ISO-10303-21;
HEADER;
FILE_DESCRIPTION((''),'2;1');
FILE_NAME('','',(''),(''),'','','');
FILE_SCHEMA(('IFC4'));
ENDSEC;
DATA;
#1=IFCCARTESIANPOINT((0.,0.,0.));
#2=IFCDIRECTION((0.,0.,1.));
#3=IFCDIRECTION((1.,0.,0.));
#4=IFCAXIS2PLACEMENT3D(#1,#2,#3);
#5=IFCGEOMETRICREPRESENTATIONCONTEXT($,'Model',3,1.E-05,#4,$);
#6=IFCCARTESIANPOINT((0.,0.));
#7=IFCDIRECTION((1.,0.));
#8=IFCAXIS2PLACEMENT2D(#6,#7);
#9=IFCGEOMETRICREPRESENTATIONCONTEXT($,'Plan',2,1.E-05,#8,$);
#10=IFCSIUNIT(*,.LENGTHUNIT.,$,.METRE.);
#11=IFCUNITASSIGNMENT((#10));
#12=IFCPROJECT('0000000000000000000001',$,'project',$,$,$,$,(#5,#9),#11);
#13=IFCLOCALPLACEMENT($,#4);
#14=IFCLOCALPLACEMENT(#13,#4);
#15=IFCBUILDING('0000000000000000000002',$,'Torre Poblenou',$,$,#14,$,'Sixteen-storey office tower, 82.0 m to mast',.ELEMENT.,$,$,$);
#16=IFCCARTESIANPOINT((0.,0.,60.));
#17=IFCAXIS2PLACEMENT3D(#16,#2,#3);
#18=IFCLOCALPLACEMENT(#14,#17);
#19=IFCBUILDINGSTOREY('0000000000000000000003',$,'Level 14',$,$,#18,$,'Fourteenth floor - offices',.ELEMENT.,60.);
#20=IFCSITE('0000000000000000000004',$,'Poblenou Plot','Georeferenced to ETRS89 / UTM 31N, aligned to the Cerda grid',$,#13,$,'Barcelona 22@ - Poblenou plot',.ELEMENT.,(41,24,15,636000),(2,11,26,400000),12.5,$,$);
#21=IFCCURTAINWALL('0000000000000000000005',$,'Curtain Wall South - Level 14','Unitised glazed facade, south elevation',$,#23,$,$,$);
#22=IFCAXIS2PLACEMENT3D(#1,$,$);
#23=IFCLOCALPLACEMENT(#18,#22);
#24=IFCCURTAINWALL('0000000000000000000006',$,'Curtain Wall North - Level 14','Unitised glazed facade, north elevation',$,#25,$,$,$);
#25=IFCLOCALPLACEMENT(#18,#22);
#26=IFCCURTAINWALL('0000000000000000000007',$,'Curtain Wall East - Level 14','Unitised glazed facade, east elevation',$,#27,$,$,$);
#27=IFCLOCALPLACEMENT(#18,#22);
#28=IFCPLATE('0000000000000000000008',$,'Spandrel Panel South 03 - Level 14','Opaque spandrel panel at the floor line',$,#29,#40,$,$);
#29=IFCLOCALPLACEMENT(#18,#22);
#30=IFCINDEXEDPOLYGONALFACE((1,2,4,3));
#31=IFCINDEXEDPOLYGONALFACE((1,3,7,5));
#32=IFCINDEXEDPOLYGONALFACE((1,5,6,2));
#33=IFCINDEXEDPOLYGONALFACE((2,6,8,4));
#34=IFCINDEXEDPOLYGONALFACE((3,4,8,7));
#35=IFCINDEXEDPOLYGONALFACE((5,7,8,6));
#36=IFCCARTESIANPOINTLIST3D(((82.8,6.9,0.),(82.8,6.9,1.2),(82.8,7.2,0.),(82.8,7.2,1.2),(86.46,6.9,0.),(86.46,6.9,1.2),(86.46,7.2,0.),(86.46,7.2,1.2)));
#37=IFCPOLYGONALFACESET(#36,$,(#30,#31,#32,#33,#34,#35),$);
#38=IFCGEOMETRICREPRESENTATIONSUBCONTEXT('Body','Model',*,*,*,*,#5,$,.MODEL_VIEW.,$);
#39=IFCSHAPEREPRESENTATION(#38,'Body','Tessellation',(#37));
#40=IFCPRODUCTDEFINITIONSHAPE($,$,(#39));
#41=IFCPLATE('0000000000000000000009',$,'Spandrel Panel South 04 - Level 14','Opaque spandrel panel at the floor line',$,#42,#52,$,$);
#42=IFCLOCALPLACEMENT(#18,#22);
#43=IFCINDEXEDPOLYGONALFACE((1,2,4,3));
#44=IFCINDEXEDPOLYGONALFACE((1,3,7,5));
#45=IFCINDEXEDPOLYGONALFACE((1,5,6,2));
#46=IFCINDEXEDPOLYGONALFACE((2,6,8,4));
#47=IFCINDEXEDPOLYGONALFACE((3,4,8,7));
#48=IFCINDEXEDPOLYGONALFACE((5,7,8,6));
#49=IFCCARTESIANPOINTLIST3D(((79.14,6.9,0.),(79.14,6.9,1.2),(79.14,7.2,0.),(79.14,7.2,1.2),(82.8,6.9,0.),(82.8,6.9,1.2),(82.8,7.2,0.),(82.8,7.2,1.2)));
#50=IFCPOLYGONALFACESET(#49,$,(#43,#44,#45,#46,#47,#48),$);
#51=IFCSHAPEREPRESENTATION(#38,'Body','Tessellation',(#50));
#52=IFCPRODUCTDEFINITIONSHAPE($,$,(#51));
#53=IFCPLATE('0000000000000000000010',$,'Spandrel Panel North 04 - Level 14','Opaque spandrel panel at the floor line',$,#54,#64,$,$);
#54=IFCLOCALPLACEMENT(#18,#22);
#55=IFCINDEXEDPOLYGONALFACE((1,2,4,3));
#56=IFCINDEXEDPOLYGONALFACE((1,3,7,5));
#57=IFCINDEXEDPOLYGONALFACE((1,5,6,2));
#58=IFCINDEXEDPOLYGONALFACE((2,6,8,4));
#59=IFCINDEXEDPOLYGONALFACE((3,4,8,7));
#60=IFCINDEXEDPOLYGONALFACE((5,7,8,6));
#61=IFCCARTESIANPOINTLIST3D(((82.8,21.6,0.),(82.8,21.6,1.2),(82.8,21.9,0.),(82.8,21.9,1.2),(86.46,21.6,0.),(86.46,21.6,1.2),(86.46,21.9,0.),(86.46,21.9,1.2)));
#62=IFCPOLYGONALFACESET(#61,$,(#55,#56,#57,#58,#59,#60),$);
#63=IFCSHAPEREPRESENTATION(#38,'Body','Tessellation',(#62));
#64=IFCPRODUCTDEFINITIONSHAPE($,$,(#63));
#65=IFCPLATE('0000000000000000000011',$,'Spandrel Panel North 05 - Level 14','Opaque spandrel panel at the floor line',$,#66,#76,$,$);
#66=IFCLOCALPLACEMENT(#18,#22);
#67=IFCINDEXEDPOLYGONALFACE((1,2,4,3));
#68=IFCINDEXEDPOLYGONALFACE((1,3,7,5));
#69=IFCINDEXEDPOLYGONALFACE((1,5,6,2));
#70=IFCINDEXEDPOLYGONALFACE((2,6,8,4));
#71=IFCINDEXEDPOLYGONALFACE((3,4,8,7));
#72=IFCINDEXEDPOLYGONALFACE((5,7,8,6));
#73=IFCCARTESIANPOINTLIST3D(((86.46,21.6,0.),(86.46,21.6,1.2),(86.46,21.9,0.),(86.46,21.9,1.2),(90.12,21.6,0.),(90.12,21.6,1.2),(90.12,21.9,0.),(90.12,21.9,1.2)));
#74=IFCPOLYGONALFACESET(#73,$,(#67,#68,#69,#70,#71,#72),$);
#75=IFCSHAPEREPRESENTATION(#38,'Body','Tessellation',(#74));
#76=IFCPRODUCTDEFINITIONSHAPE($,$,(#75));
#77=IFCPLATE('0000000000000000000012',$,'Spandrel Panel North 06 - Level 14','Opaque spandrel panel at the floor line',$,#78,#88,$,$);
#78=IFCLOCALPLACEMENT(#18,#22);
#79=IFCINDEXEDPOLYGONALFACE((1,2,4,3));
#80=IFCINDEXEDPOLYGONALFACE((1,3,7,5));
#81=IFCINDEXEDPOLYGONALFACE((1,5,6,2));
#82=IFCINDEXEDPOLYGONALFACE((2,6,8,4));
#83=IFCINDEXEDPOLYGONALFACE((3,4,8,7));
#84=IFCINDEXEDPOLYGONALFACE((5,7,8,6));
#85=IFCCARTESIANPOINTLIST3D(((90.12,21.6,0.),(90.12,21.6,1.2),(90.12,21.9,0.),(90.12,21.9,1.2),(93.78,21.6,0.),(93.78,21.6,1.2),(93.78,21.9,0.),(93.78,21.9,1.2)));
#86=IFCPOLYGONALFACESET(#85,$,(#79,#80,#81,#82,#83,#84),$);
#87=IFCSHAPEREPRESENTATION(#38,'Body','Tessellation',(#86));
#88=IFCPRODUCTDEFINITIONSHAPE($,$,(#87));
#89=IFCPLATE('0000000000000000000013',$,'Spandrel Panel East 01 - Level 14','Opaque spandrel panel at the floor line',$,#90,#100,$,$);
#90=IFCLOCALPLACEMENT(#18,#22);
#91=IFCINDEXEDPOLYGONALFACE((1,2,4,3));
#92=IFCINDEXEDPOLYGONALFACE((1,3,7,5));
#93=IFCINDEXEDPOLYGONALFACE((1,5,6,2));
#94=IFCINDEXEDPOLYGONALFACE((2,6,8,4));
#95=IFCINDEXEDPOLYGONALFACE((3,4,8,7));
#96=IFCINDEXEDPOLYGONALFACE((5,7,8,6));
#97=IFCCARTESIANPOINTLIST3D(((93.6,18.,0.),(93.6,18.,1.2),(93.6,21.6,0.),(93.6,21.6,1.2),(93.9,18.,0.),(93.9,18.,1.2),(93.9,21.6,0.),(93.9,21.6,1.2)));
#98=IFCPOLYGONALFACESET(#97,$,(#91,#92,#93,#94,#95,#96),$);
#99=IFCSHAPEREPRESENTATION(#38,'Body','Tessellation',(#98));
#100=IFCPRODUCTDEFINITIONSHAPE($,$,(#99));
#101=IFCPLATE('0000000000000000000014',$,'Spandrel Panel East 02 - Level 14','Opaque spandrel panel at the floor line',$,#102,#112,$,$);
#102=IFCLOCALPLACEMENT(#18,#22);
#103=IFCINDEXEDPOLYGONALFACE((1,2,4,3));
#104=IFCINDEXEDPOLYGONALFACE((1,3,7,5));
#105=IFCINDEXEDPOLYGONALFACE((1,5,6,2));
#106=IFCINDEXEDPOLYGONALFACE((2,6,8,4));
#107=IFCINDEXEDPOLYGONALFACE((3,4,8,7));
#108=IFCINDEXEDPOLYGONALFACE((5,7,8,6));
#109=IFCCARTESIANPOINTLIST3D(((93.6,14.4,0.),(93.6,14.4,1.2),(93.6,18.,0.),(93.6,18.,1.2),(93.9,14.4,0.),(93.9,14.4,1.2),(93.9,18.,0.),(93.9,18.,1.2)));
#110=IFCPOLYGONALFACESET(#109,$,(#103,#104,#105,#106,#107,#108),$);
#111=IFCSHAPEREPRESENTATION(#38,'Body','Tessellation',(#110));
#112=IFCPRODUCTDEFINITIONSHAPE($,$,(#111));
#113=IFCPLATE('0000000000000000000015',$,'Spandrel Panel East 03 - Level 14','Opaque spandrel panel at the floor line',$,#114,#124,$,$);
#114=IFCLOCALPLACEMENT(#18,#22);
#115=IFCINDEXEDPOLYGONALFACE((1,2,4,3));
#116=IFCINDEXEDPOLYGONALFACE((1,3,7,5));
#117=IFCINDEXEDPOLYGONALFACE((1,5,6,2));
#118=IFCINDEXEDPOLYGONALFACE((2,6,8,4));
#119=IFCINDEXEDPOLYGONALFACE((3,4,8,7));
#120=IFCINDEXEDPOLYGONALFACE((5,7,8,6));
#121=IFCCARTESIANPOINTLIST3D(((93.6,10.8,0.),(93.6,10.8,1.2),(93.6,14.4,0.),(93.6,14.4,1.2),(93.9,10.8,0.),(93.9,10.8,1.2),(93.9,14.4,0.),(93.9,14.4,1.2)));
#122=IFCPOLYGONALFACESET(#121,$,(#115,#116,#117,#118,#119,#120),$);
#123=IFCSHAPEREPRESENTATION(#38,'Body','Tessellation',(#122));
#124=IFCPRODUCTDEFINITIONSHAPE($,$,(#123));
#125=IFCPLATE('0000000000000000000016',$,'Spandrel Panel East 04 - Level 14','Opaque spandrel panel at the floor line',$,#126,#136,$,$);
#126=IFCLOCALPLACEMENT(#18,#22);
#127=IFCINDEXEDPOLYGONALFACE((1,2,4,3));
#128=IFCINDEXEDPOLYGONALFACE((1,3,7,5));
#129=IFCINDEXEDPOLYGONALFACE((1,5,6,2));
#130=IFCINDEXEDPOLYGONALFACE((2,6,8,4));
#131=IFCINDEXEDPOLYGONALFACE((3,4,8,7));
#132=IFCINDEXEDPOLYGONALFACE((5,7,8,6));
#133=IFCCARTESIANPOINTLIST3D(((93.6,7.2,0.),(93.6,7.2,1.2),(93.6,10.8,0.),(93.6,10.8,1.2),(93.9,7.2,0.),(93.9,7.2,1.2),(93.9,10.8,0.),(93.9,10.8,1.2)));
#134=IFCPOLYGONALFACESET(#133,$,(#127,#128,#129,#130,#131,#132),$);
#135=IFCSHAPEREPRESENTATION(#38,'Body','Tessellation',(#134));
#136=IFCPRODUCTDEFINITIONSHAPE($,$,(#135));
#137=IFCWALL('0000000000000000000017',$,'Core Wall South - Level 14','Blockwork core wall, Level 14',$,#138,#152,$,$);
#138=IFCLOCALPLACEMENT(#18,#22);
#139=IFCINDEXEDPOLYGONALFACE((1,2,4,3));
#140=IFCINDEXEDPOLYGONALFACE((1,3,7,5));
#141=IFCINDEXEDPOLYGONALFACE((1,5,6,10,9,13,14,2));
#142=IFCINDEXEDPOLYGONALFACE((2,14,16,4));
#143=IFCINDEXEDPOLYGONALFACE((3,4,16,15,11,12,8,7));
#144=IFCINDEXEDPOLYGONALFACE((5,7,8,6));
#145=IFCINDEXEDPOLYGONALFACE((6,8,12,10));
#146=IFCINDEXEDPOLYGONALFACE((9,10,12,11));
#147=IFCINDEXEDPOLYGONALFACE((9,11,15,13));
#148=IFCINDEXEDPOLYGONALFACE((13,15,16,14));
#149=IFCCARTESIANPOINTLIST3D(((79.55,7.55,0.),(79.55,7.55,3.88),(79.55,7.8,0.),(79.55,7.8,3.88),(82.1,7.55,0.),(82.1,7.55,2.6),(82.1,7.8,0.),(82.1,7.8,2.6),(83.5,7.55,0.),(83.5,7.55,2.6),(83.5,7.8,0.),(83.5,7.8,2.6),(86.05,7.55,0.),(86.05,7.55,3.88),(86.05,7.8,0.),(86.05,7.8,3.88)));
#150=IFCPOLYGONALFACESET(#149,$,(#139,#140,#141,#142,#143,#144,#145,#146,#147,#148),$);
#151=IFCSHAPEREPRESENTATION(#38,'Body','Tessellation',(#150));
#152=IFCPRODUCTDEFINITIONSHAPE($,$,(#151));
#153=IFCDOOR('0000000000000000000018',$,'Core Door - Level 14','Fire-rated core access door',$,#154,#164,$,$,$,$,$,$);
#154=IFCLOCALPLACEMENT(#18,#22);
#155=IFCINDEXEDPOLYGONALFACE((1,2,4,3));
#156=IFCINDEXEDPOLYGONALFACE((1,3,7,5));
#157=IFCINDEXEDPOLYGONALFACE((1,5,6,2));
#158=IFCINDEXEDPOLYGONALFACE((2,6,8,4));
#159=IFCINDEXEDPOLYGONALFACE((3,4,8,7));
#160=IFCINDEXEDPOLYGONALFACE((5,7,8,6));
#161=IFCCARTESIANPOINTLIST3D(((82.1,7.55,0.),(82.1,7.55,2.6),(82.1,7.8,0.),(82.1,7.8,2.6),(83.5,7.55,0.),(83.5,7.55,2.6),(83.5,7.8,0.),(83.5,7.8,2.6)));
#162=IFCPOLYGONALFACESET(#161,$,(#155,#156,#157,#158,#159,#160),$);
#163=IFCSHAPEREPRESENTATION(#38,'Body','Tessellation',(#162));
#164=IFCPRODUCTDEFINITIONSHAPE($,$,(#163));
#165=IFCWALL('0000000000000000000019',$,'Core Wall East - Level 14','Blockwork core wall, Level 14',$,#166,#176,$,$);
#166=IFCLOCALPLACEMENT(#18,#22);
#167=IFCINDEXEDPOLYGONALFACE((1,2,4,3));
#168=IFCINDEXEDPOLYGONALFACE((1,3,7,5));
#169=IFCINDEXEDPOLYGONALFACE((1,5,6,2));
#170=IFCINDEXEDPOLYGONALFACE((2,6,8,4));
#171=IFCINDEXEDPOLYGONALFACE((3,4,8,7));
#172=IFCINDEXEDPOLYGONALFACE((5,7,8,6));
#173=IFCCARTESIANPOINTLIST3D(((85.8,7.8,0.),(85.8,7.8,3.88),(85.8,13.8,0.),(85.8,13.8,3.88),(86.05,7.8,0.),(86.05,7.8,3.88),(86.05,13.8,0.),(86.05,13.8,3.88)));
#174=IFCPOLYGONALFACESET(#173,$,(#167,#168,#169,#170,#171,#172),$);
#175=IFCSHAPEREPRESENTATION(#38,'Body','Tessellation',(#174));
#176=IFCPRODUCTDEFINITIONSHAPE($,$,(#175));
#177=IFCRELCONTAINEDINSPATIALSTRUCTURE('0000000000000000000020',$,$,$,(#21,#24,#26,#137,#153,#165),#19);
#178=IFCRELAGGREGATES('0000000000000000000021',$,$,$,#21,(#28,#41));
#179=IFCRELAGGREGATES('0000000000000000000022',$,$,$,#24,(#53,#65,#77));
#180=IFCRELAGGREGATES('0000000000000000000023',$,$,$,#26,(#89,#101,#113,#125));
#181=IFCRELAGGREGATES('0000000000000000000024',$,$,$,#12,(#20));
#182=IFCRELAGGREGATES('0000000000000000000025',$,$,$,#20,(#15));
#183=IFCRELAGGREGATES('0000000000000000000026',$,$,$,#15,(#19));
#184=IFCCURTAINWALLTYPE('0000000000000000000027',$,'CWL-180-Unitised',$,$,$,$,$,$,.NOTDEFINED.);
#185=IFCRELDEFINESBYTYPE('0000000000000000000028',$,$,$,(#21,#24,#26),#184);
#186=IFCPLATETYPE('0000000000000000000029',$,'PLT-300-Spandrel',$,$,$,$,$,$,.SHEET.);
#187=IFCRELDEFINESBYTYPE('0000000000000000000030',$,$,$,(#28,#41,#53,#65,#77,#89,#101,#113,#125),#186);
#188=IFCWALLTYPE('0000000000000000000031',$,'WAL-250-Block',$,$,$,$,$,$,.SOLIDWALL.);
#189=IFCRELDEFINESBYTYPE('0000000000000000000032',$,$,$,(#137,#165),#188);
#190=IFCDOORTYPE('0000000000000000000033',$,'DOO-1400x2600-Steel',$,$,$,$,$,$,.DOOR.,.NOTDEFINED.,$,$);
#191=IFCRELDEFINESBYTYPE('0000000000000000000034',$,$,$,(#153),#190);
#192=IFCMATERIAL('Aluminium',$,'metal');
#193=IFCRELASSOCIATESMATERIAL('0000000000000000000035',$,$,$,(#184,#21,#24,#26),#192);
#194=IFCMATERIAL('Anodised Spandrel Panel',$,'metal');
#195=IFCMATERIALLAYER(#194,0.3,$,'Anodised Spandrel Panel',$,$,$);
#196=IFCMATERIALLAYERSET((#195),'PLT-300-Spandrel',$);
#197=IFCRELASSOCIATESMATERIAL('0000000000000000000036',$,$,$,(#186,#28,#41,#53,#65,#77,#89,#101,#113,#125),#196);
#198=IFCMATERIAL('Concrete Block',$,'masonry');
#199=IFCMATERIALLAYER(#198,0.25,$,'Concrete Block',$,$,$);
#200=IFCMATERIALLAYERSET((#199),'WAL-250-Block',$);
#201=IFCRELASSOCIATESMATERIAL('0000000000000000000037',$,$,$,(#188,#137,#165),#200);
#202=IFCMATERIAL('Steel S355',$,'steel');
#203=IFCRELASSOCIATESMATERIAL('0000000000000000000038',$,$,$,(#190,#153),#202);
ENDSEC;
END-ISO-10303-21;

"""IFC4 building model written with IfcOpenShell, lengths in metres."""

from ifc_helpers import new_model, si_unit, frame, origin_with_axes, origin_2d_with_axis, place, context, subcontext, project, spatial, line, indexed_curve, outline, extrude, material, layer, layer_set, layer_usage, type_object, element, fill, aggregate, save


model = new_model("IFC4")

# Units and contexts
model_context = context("Model", 3, precision=1e-05, world=origin_with_axes())
plan_context = context("Plan", 2, precision=1e-05, world=origin_2d_with_axis())
body_context = subcontext(model_context, "Body", "Model", "MODEL_VIEW")
ifc_project = project(units=[si_unit("LENGTHUNIT", "METRE")], contexts=[model_context, plan_context])

# Site, building, storey
site_placement = place(None, origin_with_axes())
site = spatial("IfcSite", under=ifc_project, at=site_placement, Name="Poblenou Plot", Description="Georeferenced to ETRS89 / UTM 31N, aligned to the Cerda grid", LongName="Barcelona 22@ - Poblenou plot", CompositionType="ELEMENT", RefLatitude=(41, 24, 15, 636000), RefLongitude=(2, 11, 26, 400000), RefElevation=12.5)
building_placement = place(site_placement, origin_with_axes())
building = spatial("IfcBuilding", under=site, at=building_placement, Name="Torre Poblenou", LongName="Sixteen-storey office tower, 82.0 m to mast", CompositionType="ELEMENT")
storey_placement = place(building_placement, frame((0.0, 0.0, 60.0), z_axis=(0.0, 0.0, 1.0), x_axis=(1.0, 0.0, 0.0)))
storey = spatial("IfcBuildingStorey", under=building, at=storey_placement, Name="Level 14", LongName="Fourteenth floor - offices", CompositionType="ELEMENT", Elevation=60.0)

# Curtain walls
ifc_material_1 = material(Name="Aluminium", Category="metal")
curtain_wall_type = type_object("IfcCurtainWallType", Name="CWL-180-Unitised", PredefinedType="NOTDEFINED", material=ifc_material_1)
curtain_wall_1_placement = place(storey_placement, frame((93.78, 7.2, 0.0), z_axis=(0.0, 0.0, 1.0), x_axis=(-1.0, 0.0, 0.0)))
curtain_wall_1 = element("IfcCurtainWall", 1, at=curtain_wall_1_placement, inside=storey, type_object=curtain_wall_type, material=ifc_material_1, Name="Curtain Wall South - Level 14", Description="Unitised glazed facade, south elevation")
curtain_wall_2_placement = place(storey_placement, frame((71.82, 21.6, 0.0), z_axis=(0.0, 0.0, 1.0), x_axis=(1.0, 0.0, 0.0)))
curtain_wall_2 = element("IfcCurtainWall", 2, at=curtain_wall_2_placement, inside=storey, type_object=curtain_wall_type, material=ifc_material_1, Name="Curtain Wall North - Level 14", Description="Unitised glazed facade, north elevation")
curtain_wall_3_placement = place(storey_placement, frame((93.6, 21.6, 0.0), z_axis=(0.0, 0.0, 1.0), x_axis=(0.0, -1.0, 0.0)))
curtain_wall_3 = element("IfcCurtainWall", 3, at=curtain_wall_3_placement, inside=storey, type_object=curtain_wall_type, material=ifc_material_1, Name="Curtain Wall East - Level 14", Description="Unitised glazed facade, east elevation")

# Plates
ifc_material_2 = material(Name="Anodised Spandrel Panel", Category="metal")
ifc_layer_1 = layer(ifc_material_2, 0.3, Name="Anodised Spandrel Panel")
ifc_layer_set_1 = layer_set([ifc_layer_1], Name="PLT-300-Spandrel")
plate_type_1 = type_object("IfcPlateType", Name="PLT-300-Spandrel", PredefinedType="SHEET", material=ifc_layer_set_1)
ifc_layer_usage_1 = layer_usage(ifc_layer_set_1, "AXIS2", "POSITIVE", 0.0)
plate_1_placement = place(curtain_wall_1_placement, frame((7.32, 0.0, 0.0), z_axis=(0.0, 0.0, 1.0), x_axis=(1.0, 0.0, 0.0)))
plate_1 = element("IfcPlate", 4, at=plate_1_placement, type_object=plate_type_1, material=ifc_layer_usage_1, Name="Spandrel Panel South 03 - Level 14", Description="Opaque spandrel panel at the floor line", context=body_context, shape_type="SweptSolid", body=[
    extrude(outline(indexed_curve([(0.0, 0.0), (3.66, 0.0), (3.66, 0.3), (0.0, 0.3)], segments=[line(1, 2, 3, 4, 1)])), origin_with_axes(), (0.0, 0.0, 1.0), 1.2),
])
ifc_layer_usage_2 = layer_usage(ifc_layer_set_1, "AXIS2", "POSITIVE", 0.0)
plate_2_placement = place(curtain_wall_1_placement, frame((10.98, 0.0, 0.0), z_axis=(0.0, 0.0, 1.0), x_axis=(1.0, 0.0, 0.0)))
plate_2 = element("IfcPlate", 5, at=plate_2_placement, type_object=plate_type_1, material=ifc_layer_usage_2, Name="Spandrel Panel South 04 - Level 14", Description="Opaque spandrel panel at the floor line", context=body_context, shape_type="SweptSolid", body=[
    extrude(outline(indexed_curve([(0.0, 0.0), (3.66, 0.0), (3.66, 0.3), (0.0, 0.3)], segments=[line(1, 2, 3, 4, 1)])), origin_with_axes(), (0.0, 0.0, 1.0), 1.2),
])
aggregate(curtain_wall_1, [plate_1, plate_2])
ifc_layer_usage_3 = layer_usage(ifc_layer_set_1, "AXIS2", "POSITIVE", 0.0)
plate_3_placement = place(curtain_wall_2_placement, frame((10.98, 0.0, 0.0), z_axis=(0.0, 0.0, 1.0), x_axis=(1.0, 0.0, 0.0)))
plate_3 = element("IfcPlate", 6, at=plate_3_placement, type_object=plate_type_1, material=ifc_layer_usage_3, Name="Spandrel Panel North 04 - Level 14", Description="Opaque spandrel panel at the floor line", context=body_context, shape_type="SweptSolid", body=[
    extrude(outline(indexed_curve([(0.0, 0.0), (3.66, 0.0), (3.66, 0.3), (0.0, 0.3)], segments=[line(1, 2, 3, 4, 1)])), origin_with_axes(), (0.0, 0.0, 1.0), 1.2),
])
ifc_layer_usage_4 = layer_usage(ifc_layer_set_1, "AXIS2", "POSITIVE", 0.0)
plate_4_placement = place(curtain_wall_2_placement, frame((14.64, 0.0, 0.0), z_axis=(0.0, 0.0, 1.0), x_axis=(1.0, 0.0, 0.0)))
plate_4 = element("IfcPlate", 7, at=plate_4_placement, type_object=plate_type_1, material=ifc_layer_usage_4, Name="Spandrel Panel North 05 - Level 14", Description="Opaque spandrel panel at the floor line", context=body_context, shape_type="SweptSolid", body=[
    extrude(outline(indexed_curve([(0.0, 0.0), (3.66, 0.0), (3.66, 0.3), (0.0, 0.3)], segments=[line(1, 2, 3, 4, 1)])), origin_with_axes(), (0.0, 0.0, 1.0), 1.2),
])
ifc_layer_usage_5 = layer_usage(ifc_layer_set_1, "AXIS2", "POSITIVE", 0.0)
plate_5_placement = place(curtain_wall_2_placement, frame((18.3, 0.0, 0.0), z_axis=(0.0, 0.0, 1.0), x_axis=(1.0, 0.0, 0.0)))
plate_5 = element("IfcPlate", 8, at=plate_5_placement, type_object=plate_type_1, material=ifc_layer_usage_5, Name="Spandrel Panel North 06 - Level 14", Description="Opaque spandrel panel at the floor line", context=body_context, shape_type="SweptSolid", body=[
    extrude(outline(indexed_curve([(0.0, 0.0), (3.66, 0.0), (3.66, 0.3), (0.0, 0.3)], segments=[line(1, 2, 3, 4, 1)])), origin_with_axes(), (0.0, 0.0, 1.0), 1.2),
])
aggregate(curtain_wall_2, [plate_3, plate_4, plate_5])
ifc_layer_usage_6 = layer_usage(ifc_layer_set_1, "AXIS2", "POSITIVE", 0.0)
plate_6_placement = place(curtain_wall_3_placement, origin_with_axes())
plate_6 = element("IfcPlate", 9, at=plate_6_placement, type_object=plate_type_1, material=ifc_layer_usage_6, Name="Spandrel Panel East 01 - Level 14", Description="Opaque spandrel panel at the floor line", context=body_context, shape_type="SweptSolid", body=[
    extrude(outline(indexed_curve([(0.0, 0.0), (3.6, 0.0), (3.6, 0.3), (0.0, 0.3)], segments=[line(1, 2, 3, 4, 1)])), origin_with_axes(), (0.0, 0.0, 1.0), 1.2),
])
ifc_layer_usage_7 = layer_usage(ifc_layer_set_1, "AXIS2", "POSITIVE", 0.0)
plate_7_placement = place(curtain_wall_3_placement, frame((3.6, 0.0, 0.0), z_axis=(0.0, 0.0, 1.0), x_axis=(1.0, 0.0, 0.0)))
plate_7 = element("IfcPlate", 10, at=plate_7_placement, type_object=plate_type_1, material=ifc_layer_usage_7, Name="Spandrel Panel East 02 - Level 14", Description="Opaque spandrel panel at the floor line", context=body_context, shape_type="SweptSolid", body=[
    extrude(outline(indexed_curve([(0.0, 0.0), (3.6, 0.0), (3.6, 0.3), (0.0, 0.3)], segments=[line(1, 2, 3, 4, 1)])), origin_with_axes(), (0.0, 0.0, 1.0), 1.2),
])
ifc_layer_usage_8 = layer_usage(ifc_layer_set_1, "AXIS2", "POSITIVE", 0.0)
plate_8_placement = place(curtain_wall_3_placement, frame((7.2, 0.0, 0.0), z_axis=(0.0, 0.0, 1.0), x_axis=(1.0, 0.0, 0.0)))
plate_8 = element("IfcPlate", 11, at=plate_8_placement, type_object=plate_type_1, material=ifc_layer_usage_8, Name="Spandrel Panel East 03 - Level 14", Description="Opaque spandrel panel at the floor line", context=body_context, shape_type="SweptSolid", body=[
    extrude(outline(indexed_curve([(0.0, 0.0), (3.6, 0.0), (3.6, 0.3), (0.0, 0.3)], segments=[line(1, 2, 3, 4, 1)])), origin_with_axes(), (0.0, 0.0, 1.0), 1.2),
])
ifc_layer_usage_9 = layer_usage(ifc_layer_set_1, "AXIS2", "POSITIVE", 0.0)
plate_9_placement = place(curtain_wall_3_placement, frame((10.8, 0.0, 0.0), z_axis=(0.0, 0.0, 1.0), x_axis=(1.0, 0.0, 0.0)))
plate_9 = element("IfcPlate", 12, at=plate_9_placement, type_object=plate_type_1, material=ifc_layer_usage_9, Name="Spandrel Panel East 04 - Level 14", Description="Opaque spandrel panel at the floor line", context=body_context, shape_type="SweptSolid", body=[
    extrude(outline(indexed_curve([(0.0, 0.0), (3.6, 0.0), (3.6, 0.3), (0.0, 0.3)], segments=[line(1, 2, 3, 4, 1)])), origin_with_axes(), (0.0, 0.0, 1.0), 1.2),
])
aggregate(curtain_wall_3, [plate_6, plate_7, plate_8, plate_9])

# Wall, opening, door
ifc_material_3 = material(Name="Concrete Block", Category="masonry")
ifc_layer_2 = layer(ifc_material_3, 0.25, Name="Concrete Block")
ifc_layer_set_2 = layer_set([ifc_layer_2], Name="WAL-250-Block")
ifc_layer_usage_10 = layer_usage(ifc_layer_set_2, "AXIS2", "POSITIVE", 0.0)
wall_type = type_object("IfcWallType", Name="WAL-250-Block", PredefinedType="SOLIDWALL", material=ifc_layer_set_2)
wall_1_placement = place(storey_placement, frame((86.05, 7.8, 0.0), z_axis=(0.0, 0.0, 1.0), x_axis=(-1.0, 0.0, 0.0)))
wall_1 = element("IfcWall", 13, at=wall_1_placement, inside=storey, type_object=wall_type, material=ifc_layer_usage_10, Name="Core Wall South - Level 14", Description="Blockwork core wall, Level 14", context=body_context, shape_type="SweptSolid", body=[
    extrude(outline(indexed_curve([(0.0, 0.0), (6.5, 0.0), (6.5, 0.25), (0.0, 0.25)], segments=[line(1, 2, 3, 4, 1)])), origin_with_axes(), (0.0, 0.0, 1.0), 3.88),
])
opening_placement = place(wall_1_placement, frame((2.55, -0.05, 0.0), z_axis=(0.0, 0.0, 1.0), x_axis=(1.0, 0.0, 0.0)))
opening = element("IfcOpeningElement", 14, at=opening_placement, cuts=wall_1, PredefinedType="OPENING", context=body_context, shape_type="SweptSolid", body=[
    extrude(outline(indexed_curve([(0.0, 0.0), (1.4, 0.0), (1.4, 0.35), (0.0, 0.35)], segments=[line(1, 2, 3, 4, 1)])), origin_with_axes(), (0.0, 0.0, 1.0), 2.6),
])
ifc_material_4 = material(Name="Steel S355", Category="steel")
door_type = type_object("IfcDoorType", Name="DOO-1400x2600-Steel", OperationType="NOTDEFINED", PredefinedType="DOOR", material=ifc_material_4)
door_placement = place(storey_placement, frame((83.5, 7.8, 0.0), z_axis=(0.0, 0.0, 1.0), x_axis=(-1.0, 0.0, 0.0)))
door = element("IfcDoor", 15, at=door_placement, inside=storey, type_object=door_type, material=ifc_material_4, Name="Core Door - Level 14", Description="Fire-rated core access door", context=body_context, shape_type="SweptSolid", body=[
    extrude(outline(indexed_curve([(0.0, 0.0), (1.4, 0.0), (1.4, 0.25), (0.0, 0.25)], segments=[line(1, 2, 3, 4, 1)])), origin_with_axes(), (0.0, 0.0, 1.0), 2.6),
])
fill(opening, door)

# Wall
ifc_layer_usage_11 = layer_usage(ifc_layer_set_2, "AXIS2", "POSITIVE", 0.0)
wall_2_placement = place(storey_placement, frame((85.8, 13.8, 0.0), z_axis=(0.0, 0.0, 1.0), x_axis=(0.0, -1.0, 0.0)))
element("IfcWall", 16, at=wall_2_placement, inside=storey, type_object=wall_type, material=ifc_layer_usage_11, Name="Core Wall East - Level 14", Description="Blockwork core wall, Level 14", context=body_context, shape_type="SweptSolid", body=[
    extrude(outline(indexed_curve([(0.0, 0.0), (6.0, 0.0), (6.0, 0.25), (0.0, 0.25)], segments=[line(1, 2, 3, 4, 1)])), origin_with_axes(), (0.0, 0.0, 1.0), 3.88),
])

save(model, "model.ifc")
